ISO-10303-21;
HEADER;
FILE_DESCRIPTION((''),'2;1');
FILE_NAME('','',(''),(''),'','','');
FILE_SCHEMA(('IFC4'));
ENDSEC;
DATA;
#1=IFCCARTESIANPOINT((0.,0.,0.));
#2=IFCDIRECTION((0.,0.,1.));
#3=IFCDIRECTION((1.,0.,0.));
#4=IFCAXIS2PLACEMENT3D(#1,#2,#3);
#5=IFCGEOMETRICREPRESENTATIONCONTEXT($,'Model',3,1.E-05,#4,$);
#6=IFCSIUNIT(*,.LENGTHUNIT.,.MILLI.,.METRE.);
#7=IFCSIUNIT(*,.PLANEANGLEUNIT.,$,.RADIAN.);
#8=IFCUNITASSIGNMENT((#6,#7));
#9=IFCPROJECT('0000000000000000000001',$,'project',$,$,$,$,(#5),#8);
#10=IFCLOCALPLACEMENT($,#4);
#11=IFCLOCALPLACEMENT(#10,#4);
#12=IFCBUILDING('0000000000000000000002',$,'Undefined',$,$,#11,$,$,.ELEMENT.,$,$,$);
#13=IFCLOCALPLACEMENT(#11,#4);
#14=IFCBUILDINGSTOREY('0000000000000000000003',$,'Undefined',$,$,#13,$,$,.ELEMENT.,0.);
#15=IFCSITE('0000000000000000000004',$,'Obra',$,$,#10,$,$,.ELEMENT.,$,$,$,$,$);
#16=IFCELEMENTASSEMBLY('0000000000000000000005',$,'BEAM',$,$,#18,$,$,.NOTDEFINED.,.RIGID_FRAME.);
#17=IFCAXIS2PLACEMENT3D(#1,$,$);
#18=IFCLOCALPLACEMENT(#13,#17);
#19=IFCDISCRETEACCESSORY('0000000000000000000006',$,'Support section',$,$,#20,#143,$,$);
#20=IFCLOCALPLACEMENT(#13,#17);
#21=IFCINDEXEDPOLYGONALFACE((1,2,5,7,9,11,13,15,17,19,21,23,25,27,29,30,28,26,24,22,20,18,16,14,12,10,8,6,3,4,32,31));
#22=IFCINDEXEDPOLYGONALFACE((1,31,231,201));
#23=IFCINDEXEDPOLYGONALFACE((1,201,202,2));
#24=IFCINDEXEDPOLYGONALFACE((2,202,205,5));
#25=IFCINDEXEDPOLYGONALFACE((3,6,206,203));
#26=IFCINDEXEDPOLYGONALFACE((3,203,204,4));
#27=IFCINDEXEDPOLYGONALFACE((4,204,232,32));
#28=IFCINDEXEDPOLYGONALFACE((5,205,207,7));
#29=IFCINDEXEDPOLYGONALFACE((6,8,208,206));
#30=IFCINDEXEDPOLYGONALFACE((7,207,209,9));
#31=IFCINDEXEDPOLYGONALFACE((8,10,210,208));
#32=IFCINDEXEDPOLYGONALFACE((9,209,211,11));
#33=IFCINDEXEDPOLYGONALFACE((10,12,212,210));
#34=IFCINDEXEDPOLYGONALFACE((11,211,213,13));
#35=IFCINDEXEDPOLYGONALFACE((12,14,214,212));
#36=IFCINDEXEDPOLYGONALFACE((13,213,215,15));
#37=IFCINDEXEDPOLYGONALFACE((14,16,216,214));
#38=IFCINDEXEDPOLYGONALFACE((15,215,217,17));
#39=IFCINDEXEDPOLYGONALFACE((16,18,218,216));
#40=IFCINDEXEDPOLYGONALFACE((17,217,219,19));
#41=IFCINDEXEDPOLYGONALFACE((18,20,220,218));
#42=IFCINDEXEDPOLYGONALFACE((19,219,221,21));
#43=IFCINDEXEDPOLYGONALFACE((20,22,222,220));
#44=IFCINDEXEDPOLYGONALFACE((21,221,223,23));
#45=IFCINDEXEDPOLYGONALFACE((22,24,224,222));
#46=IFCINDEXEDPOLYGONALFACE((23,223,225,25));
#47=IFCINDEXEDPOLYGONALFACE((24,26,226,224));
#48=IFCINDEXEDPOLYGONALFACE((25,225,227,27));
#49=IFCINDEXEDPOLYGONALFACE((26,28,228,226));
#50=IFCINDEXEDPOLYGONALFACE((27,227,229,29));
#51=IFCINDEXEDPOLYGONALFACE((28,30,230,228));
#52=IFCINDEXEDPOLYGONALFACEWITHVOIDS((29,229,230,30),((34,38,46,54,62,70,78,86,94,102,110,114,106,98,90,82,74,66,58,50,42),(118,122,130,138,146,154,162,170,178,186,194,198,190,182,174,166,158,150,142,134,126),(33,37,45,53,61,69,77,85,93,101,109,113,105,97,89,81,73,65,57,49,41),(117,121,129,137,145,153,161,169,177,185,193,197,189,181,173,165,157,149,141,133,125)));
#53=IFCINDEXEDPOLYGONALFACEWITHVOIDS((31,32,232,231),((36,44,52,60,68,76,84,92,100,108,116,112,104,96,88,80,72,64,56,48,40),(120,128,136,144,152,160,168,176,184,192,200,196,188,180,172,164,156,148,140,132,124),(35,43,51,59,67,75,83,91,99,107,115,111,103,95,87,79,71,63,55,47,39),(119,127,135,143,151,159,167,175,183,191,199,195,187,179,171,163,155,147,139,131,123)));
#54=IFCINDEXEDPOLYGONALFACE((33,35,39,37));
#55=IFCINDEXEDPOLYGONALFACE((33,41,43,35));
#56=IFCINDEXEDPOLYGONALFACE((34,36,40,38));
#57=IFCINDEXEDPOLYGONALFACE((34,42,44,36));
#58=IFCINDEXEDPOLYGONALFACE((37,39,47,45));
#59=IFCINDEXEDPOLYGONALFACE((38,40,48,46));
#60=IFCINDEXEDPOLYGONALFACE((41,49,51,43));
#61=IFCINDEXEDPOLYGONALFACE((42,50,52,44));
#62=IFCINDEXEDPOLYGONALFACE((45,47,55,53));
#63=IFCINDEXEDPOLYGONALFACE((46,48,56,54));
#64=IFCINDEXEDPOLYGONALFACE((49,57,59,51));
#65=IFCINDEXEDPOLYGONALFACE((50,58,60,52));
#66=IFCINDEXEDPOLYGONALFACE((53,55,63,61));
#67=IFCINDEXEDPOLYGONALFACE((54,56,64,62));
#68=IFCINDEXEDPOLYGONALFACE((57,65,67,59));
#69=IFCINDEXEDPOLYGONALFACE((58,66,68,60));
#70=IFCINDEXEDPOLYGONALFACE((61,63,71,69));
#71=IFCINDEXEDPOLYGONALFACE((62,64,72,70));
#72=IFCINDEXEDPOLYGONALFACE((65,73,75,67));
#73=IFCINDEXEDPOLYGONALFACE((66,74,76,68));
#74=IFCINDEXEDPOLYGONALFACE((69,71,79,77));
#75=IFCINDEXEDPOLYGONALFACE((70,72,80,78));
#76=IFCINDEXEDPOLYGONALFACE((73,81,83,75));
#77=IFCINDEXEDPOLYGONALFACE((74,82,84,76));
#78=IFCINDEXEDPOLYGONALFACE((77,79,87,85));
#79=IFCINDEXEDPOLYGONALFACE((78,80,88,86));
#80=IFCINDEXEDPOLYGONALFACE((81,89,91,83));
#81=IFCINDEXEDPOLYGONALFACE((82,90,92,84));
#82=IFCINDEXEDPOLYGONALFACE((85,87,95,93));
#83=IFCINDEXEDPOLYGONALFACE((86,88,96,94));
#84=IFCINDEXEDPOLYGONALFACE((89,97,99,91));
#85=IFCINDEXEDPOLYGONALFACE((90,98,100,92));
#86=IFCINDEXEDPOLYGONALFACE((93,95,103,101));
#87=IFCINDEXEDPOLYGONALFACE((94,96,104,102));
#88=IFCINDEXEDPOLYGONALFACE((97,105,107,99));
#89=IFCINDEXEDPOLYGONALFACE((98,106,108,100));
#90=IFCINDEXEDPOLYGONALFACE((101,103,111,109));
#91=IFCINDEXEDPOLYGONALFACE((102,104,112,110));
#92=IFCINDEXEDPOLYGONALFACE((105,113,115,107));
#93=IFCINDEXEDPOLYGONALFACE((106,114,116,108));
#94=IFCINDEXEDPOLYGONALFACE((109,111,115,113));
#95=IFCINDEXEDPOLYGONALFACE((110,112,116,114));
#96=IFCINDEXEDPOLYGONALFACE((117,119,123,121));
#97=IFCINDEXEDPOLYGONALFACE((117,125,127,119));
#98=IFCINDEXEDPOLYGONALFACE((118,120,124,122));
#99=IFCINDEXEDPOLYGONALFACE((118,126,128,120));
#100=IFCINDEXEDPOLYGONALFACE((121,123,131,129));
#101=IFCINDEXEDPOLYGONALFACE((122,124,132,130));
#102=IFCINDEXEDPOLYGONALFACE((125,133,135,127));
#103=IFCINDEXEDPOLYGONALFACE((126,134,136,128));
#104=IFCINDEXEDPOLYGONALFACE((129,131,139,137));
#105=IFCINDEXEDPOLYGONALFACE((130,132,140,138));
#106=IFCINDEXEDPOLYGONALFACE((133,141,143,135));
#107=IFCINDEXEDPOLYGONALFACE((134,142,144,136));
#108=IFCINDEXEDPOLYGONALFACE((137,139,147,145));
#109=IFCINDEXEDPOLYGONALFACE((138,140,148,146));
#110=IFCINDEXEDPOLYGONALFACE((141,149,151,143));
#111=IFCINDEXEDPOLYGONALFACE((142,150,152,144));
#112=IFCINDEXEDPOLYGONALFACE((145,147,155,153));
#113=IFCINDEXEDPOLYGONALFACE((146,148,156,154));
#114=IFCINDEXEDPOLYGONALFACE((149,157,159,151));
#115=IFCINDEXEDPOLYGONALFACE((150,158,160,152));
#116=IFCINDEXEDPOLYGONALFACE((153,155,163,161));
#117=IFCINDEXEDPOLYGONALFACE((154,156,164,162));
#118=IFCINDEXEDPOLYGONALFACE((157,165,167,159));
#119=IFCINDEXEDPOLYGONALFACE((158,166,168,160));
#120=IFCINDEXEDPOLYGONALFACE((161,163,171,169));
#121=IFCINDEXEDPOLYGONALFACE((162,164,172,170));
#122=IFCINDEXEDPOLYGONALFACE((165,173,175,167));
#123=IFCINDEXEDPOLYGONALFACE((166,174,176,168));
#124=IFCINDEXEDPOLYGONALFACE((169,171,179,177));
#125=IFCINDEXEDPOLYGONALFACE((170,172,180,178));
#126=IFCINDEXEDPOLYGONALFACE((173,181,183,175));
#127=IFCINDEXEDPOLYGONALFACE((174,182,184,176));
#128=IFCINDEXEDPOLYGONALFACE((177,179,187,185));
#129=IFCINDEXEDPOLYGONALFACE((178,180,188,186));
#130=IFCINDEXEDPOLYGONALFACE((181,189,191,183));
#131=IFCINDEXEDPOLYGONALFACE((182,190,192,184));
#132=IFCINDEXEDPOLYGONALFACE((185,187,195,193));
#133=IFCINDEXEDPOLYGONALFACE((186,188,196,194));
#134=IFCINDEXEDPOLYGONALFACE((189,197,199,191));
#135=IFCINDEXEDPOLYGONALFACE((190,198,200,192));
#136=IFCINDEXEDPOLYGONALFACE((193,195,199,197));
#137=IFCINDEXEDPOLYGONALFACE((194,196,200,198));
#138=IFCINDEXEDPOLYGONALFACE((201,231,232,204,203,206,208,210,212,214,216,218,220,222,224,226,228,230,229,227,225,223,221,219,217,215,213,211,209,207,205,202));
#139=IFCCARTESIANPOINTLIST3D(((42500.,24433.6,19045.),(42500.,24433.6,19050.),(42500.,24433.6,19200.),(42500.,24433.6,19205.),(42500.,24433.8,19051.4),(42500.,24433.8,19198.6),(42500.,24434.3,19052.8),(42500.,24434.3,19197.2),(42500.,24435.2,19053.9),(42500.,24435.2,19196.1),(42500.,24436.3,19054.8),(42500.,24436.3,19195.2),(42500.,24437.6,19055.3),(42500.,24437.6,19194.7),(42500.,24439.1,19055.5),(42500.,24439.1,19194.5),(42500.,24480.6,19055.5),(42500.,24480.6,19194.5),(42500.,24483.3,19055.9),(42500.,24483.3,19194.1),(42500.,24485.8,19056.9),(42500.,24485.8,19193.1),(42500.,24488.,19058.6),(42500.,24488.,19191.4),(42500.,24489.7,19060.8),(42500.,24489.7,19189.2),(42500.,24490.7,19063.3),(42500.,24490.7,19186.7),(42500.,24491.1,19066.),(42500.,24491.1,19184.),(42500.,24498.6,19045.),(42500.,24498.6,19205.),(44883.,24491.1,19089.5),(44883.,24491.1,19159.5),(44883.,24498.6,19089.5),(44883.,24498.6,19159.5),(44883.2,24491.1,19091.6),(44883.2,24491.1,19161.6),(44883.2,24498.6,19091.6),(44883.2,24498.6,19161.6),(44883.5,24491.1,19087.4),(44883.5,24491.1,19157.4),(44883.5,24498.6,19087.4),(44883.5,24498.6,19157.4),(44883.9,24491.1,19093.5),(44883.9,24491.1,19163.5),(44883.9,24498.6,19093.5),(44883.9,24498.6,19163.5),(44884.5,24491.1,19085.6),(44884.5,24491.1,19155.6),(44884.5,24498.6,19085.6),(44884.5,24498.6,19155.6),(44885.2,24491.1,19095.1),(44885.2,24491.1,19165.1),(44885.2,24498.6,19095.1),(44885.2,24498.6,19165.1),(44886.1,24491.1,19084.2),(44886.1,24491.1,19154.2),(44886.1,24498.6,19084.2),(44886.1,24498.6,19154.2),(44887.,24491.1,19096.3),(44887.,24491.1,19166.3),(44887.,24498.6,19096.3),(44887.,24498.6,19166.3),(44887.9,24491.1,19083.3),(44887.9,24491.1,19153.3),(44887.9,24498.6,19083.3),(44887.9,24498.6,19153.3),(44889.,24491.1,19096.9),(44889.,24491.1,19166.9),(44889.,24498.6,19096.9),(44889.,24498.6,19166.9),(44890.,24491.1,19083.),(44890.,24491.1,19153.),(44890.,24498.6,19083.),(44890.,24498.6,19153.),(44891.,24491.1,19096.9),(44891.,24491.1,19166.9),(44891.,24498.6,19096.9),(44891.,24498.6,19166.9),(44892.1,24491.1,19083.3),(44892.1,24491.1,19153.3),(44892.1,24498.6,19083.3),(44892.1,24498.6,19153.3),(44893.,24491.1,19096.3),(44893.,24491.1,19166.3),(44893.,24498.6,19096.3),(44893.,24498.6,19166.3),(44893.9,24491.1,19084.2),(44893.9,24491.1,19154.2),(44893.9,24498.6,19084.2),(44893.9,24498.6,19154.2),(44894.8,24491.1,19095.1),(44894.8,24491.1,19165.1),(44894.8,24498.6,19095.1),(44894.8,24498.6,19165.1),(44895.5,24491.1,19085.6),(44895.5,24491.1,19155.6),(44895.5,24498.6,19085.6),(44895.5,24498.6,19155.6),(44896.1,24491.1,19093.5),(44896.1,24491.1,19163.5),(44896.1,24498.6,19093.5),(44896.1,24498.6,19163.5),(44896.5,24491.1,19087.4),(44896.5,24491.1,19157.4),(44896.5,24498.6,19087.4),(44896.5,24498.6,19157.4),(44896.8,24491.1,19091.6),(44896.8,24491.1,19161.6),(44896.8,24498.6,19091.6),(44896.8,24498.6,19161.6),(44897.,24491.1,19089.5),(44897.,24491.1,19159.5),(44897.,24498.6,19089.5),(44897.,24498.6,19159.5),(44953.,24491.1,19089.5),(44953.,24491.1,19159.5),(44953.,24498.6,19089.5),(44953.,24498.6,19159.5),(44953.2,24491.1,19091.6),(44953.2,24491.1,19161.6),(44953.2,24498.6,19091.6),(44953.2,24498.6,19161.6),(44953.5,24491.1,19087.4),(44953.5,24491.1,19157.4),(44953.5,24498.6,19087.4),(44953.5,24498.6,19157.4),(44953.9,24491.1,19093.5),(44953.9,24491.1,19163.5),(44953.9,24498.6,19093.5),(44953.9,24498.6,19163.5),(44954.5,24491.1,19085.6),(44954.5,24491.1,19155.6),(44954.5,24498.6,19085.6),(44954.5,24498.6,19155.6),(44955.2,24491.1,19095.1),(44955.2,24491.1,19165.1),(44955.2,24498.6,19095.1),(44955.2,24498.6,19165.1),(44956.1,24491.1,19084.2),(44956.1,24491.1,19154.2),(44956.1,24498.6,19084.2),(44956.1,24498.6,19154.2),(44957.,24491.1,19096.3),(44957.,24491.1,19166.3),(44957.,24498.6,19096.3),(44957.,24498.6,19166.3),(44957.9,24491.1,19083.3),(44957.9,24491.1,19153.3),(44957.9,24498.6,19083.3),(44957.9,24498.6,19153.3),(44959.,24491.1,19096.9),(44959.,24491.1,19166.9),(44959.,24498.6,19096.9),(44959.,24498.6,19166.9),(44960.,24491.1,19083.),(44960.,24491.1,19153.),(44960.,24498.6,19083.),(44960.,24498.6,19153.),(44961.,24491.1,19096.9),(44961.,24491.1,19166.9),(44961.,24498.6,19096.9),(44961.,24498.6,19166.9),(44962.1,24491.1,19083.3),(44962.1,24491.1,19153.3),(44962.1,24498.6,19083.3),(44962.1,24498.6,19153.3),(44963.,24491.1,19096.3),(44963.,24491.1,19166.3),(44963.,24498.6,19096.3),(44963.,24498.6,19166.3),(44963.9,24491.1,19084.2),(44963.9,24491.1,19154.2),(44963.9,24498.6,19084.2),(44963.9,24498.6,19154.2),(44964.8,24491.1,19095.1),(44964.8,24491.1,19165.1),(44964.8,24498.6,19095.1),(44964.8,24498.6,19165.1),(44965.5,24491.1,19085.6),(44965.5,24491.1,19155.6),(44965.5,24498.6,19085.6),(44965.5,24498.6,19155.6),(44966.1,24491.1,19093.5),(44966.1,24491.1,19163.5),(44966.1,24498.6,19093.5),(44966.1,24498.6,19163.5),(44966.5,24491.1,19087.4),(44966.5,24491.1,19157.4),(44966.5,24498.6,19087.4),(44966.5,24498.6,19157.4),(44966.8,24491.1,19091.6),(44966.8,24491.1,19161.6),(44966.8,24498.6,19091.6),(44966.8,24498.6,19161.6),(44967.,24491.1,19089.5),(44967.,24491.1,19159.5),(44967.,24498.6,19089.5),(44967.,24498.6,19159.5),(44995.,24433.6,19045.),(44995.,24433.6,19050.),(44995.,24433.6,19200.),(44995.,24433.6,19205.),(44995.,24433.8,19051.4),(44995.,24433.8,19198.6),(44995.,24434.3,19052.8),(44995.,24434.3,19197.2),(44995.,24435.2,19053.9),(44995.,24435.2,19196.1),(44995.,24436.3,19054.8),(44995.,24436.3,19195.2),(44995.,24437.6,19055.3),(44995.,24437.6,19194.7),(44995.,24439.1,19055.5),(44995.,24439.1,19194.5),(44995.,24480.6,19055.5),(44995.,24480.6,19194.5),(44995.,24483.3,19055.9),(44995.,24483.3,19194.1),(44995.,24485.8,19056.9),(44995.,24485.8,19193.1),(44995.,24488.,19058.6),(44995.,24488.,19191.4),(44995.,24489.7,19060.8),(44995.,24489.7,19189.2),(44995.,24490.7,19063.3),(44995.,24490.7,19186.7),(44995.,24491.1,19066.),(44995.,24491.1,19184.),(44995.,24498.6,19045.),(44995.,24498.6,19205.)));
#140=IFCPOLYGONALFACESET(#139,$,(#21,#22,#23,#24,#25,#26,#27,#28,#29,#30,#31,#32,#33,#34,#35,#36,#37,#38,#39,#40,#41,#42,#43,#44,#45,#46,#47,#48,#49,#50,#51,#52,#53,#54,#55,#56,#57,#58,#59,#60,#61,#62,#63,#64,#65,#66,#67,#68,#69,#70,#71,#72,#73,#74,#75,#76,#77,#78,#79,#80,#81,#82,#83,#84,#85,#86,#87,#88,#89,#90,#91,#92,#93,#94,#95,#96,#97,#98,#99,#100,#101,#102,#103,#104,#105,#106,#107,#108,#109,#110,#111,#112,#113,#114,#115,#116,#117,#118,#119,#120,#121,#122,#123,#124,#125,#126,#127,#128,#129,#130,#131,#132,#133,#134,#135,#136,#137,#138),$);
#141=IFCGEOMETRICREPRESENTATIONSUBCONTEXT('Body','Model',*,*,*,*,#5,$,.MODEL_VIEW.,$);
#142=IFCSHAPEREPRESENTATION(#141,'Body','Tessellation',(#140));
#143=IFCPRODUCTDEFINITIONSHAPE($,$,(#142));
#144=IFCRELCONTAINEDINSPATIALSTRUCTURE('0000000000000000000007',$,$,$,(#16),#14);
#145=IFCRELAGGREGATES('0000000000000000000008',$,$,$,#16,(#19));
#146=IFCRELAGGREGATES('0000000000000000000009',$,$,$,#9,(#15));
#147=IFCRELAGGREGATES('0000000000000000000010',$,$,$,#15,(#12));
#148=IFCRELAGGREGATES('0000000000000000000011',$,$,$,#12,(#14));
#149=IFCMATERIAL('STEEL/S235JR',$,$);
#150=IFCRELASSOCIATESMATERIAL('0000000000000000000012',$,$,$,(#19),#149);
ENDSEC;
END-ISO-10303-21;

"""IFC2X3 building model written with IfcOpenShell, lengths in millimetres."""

from ifc_helpers import new_model, si_unit, frame, origin_with_axes, origin_2d_with_axis, place, context, subcontext, project, spatial, circle, u_section, extrude, clip, halfspace, source, transform, mapped, material, element, aggregate, save


model = new_model("IFC2X3")

# Units and contexts
model_context = context("Model", 3, precision=1e-05, world=origin_with_axes())
body_context = subcontext(model_context, "Body", "Model", "MODEL_VIEW")
ifc_project = project(units=[si_unit("LENGTHUNIT", "METRE", prefix="MILLI"), si_unit("PLANEANGLEUNIT", "RADIAN")], contexts=[model_context])

# Site, building, storey
site_placement = place(None, origin_with_axes())
site = spatial("IfcSite", under=ifc_project, at=site_placement, Name="Obra", CompositionType="ELEMENT")
building_placement = place(site_placement, origin_with_axes())
building = spatial("IfcBuilding", under=site, at=building_placement, Name="Undefined", CompositionType="ELEMENT")
storey_placement = place(building_placement, origin_with_axes())
storey = spatial("IfcBuildingStorey", under=building, at=storey_placement, Name="Undefined", CompositionType="ELEMENT", Elevation=0.0)

# Shared definitions
ifc_material_1 = material(Name="STEEL/S235JR")

# Shared definitions
shared_shape_1 = source(origin_with_axes(), body_context, "Body", "SweptSolid", [
    extrude(circle(Radius=7.0, at=origin_2d_with_axis()), frame((0.0, -3.9, 0.0), z_axis=(0.0, 1.0, 0.0), x_axis=(1.0, 0.0, 0.0)), (0.0, 0.0, 1.0), 7.7),
])

# Element assembly, discrete accessory, opening
assembly_1_placement = place(storey_placement, origin_with_axes())
assembly_1 = element("IfcElementAssembly", 1, at=assembly_1_placement, inside=storey, Name="BEAM", AssemblyPlace="NOTDEFINED", PredefinedType="RIGID_FRAME")
discrete_accessory_1_placement = place(assembly_1_placement, frame((42500.0, 24466.1, 19125.0), z_axis=(0.0, 0.0, 1.0), x_axis=(1.0, 0.0, 0.0)))
discrete_accessory_1 = element("IfcDiscreteAccessory", 2, at=discrete_accessory_1_placement, material=ifc_material_1, Name="Support section", context=body_context, shape_type="Clipping", body=[
    clip(extrude(u_section(Depth=160.0, FlangeWidth=65.0, WebThickness=7.5, FlangeThickness=10.5, FilletRadius=10.5, EdgeRadius=5.5, at=origin_2d_with_axis()), frame((2495.0, 0.0, 0.0), z_axis=(-1.0, 0.0, 0.0), x_axis=(0.0, -1.0, 0.0)), (0.0, 0.0, 1.0), 2495.0), halfspace(frame((2495.0, 0.0, 166.3), z_axis=(1.0, 0.0, 0.0), x_axis=(0.0, 1.0, 0.0)), False)),
])
opening_1_placement = place(assembly_1_placement, frame((44960.0, 24494.8, 19160.0), z_axis=(-1.0, 0.0, 0.0), x_axis=(0.0, 0.0, -1.0)))
element("IfcOpeningElement", 3, at=opening_1_placement, cuts=discrete_accessory_1, ObjectType="Opening", context=body_context, shape_type="MappedRepresentation", body=[
    mapped(shared_shape_1, transform((0.0, 0.0, 0.0))),
    mapped(shared_shape_1, transform((0.0, 0.0, 70.0))),
    mapped(shared_shape_1, transform((70.0, 0.0, 0.0))),
    mapped(shared_shape_1, transform((70.0, 0.0, 70.0))),
])
aggregate(assembly_1, [discrete_accessory_1])

save(model, "model.ifc")
